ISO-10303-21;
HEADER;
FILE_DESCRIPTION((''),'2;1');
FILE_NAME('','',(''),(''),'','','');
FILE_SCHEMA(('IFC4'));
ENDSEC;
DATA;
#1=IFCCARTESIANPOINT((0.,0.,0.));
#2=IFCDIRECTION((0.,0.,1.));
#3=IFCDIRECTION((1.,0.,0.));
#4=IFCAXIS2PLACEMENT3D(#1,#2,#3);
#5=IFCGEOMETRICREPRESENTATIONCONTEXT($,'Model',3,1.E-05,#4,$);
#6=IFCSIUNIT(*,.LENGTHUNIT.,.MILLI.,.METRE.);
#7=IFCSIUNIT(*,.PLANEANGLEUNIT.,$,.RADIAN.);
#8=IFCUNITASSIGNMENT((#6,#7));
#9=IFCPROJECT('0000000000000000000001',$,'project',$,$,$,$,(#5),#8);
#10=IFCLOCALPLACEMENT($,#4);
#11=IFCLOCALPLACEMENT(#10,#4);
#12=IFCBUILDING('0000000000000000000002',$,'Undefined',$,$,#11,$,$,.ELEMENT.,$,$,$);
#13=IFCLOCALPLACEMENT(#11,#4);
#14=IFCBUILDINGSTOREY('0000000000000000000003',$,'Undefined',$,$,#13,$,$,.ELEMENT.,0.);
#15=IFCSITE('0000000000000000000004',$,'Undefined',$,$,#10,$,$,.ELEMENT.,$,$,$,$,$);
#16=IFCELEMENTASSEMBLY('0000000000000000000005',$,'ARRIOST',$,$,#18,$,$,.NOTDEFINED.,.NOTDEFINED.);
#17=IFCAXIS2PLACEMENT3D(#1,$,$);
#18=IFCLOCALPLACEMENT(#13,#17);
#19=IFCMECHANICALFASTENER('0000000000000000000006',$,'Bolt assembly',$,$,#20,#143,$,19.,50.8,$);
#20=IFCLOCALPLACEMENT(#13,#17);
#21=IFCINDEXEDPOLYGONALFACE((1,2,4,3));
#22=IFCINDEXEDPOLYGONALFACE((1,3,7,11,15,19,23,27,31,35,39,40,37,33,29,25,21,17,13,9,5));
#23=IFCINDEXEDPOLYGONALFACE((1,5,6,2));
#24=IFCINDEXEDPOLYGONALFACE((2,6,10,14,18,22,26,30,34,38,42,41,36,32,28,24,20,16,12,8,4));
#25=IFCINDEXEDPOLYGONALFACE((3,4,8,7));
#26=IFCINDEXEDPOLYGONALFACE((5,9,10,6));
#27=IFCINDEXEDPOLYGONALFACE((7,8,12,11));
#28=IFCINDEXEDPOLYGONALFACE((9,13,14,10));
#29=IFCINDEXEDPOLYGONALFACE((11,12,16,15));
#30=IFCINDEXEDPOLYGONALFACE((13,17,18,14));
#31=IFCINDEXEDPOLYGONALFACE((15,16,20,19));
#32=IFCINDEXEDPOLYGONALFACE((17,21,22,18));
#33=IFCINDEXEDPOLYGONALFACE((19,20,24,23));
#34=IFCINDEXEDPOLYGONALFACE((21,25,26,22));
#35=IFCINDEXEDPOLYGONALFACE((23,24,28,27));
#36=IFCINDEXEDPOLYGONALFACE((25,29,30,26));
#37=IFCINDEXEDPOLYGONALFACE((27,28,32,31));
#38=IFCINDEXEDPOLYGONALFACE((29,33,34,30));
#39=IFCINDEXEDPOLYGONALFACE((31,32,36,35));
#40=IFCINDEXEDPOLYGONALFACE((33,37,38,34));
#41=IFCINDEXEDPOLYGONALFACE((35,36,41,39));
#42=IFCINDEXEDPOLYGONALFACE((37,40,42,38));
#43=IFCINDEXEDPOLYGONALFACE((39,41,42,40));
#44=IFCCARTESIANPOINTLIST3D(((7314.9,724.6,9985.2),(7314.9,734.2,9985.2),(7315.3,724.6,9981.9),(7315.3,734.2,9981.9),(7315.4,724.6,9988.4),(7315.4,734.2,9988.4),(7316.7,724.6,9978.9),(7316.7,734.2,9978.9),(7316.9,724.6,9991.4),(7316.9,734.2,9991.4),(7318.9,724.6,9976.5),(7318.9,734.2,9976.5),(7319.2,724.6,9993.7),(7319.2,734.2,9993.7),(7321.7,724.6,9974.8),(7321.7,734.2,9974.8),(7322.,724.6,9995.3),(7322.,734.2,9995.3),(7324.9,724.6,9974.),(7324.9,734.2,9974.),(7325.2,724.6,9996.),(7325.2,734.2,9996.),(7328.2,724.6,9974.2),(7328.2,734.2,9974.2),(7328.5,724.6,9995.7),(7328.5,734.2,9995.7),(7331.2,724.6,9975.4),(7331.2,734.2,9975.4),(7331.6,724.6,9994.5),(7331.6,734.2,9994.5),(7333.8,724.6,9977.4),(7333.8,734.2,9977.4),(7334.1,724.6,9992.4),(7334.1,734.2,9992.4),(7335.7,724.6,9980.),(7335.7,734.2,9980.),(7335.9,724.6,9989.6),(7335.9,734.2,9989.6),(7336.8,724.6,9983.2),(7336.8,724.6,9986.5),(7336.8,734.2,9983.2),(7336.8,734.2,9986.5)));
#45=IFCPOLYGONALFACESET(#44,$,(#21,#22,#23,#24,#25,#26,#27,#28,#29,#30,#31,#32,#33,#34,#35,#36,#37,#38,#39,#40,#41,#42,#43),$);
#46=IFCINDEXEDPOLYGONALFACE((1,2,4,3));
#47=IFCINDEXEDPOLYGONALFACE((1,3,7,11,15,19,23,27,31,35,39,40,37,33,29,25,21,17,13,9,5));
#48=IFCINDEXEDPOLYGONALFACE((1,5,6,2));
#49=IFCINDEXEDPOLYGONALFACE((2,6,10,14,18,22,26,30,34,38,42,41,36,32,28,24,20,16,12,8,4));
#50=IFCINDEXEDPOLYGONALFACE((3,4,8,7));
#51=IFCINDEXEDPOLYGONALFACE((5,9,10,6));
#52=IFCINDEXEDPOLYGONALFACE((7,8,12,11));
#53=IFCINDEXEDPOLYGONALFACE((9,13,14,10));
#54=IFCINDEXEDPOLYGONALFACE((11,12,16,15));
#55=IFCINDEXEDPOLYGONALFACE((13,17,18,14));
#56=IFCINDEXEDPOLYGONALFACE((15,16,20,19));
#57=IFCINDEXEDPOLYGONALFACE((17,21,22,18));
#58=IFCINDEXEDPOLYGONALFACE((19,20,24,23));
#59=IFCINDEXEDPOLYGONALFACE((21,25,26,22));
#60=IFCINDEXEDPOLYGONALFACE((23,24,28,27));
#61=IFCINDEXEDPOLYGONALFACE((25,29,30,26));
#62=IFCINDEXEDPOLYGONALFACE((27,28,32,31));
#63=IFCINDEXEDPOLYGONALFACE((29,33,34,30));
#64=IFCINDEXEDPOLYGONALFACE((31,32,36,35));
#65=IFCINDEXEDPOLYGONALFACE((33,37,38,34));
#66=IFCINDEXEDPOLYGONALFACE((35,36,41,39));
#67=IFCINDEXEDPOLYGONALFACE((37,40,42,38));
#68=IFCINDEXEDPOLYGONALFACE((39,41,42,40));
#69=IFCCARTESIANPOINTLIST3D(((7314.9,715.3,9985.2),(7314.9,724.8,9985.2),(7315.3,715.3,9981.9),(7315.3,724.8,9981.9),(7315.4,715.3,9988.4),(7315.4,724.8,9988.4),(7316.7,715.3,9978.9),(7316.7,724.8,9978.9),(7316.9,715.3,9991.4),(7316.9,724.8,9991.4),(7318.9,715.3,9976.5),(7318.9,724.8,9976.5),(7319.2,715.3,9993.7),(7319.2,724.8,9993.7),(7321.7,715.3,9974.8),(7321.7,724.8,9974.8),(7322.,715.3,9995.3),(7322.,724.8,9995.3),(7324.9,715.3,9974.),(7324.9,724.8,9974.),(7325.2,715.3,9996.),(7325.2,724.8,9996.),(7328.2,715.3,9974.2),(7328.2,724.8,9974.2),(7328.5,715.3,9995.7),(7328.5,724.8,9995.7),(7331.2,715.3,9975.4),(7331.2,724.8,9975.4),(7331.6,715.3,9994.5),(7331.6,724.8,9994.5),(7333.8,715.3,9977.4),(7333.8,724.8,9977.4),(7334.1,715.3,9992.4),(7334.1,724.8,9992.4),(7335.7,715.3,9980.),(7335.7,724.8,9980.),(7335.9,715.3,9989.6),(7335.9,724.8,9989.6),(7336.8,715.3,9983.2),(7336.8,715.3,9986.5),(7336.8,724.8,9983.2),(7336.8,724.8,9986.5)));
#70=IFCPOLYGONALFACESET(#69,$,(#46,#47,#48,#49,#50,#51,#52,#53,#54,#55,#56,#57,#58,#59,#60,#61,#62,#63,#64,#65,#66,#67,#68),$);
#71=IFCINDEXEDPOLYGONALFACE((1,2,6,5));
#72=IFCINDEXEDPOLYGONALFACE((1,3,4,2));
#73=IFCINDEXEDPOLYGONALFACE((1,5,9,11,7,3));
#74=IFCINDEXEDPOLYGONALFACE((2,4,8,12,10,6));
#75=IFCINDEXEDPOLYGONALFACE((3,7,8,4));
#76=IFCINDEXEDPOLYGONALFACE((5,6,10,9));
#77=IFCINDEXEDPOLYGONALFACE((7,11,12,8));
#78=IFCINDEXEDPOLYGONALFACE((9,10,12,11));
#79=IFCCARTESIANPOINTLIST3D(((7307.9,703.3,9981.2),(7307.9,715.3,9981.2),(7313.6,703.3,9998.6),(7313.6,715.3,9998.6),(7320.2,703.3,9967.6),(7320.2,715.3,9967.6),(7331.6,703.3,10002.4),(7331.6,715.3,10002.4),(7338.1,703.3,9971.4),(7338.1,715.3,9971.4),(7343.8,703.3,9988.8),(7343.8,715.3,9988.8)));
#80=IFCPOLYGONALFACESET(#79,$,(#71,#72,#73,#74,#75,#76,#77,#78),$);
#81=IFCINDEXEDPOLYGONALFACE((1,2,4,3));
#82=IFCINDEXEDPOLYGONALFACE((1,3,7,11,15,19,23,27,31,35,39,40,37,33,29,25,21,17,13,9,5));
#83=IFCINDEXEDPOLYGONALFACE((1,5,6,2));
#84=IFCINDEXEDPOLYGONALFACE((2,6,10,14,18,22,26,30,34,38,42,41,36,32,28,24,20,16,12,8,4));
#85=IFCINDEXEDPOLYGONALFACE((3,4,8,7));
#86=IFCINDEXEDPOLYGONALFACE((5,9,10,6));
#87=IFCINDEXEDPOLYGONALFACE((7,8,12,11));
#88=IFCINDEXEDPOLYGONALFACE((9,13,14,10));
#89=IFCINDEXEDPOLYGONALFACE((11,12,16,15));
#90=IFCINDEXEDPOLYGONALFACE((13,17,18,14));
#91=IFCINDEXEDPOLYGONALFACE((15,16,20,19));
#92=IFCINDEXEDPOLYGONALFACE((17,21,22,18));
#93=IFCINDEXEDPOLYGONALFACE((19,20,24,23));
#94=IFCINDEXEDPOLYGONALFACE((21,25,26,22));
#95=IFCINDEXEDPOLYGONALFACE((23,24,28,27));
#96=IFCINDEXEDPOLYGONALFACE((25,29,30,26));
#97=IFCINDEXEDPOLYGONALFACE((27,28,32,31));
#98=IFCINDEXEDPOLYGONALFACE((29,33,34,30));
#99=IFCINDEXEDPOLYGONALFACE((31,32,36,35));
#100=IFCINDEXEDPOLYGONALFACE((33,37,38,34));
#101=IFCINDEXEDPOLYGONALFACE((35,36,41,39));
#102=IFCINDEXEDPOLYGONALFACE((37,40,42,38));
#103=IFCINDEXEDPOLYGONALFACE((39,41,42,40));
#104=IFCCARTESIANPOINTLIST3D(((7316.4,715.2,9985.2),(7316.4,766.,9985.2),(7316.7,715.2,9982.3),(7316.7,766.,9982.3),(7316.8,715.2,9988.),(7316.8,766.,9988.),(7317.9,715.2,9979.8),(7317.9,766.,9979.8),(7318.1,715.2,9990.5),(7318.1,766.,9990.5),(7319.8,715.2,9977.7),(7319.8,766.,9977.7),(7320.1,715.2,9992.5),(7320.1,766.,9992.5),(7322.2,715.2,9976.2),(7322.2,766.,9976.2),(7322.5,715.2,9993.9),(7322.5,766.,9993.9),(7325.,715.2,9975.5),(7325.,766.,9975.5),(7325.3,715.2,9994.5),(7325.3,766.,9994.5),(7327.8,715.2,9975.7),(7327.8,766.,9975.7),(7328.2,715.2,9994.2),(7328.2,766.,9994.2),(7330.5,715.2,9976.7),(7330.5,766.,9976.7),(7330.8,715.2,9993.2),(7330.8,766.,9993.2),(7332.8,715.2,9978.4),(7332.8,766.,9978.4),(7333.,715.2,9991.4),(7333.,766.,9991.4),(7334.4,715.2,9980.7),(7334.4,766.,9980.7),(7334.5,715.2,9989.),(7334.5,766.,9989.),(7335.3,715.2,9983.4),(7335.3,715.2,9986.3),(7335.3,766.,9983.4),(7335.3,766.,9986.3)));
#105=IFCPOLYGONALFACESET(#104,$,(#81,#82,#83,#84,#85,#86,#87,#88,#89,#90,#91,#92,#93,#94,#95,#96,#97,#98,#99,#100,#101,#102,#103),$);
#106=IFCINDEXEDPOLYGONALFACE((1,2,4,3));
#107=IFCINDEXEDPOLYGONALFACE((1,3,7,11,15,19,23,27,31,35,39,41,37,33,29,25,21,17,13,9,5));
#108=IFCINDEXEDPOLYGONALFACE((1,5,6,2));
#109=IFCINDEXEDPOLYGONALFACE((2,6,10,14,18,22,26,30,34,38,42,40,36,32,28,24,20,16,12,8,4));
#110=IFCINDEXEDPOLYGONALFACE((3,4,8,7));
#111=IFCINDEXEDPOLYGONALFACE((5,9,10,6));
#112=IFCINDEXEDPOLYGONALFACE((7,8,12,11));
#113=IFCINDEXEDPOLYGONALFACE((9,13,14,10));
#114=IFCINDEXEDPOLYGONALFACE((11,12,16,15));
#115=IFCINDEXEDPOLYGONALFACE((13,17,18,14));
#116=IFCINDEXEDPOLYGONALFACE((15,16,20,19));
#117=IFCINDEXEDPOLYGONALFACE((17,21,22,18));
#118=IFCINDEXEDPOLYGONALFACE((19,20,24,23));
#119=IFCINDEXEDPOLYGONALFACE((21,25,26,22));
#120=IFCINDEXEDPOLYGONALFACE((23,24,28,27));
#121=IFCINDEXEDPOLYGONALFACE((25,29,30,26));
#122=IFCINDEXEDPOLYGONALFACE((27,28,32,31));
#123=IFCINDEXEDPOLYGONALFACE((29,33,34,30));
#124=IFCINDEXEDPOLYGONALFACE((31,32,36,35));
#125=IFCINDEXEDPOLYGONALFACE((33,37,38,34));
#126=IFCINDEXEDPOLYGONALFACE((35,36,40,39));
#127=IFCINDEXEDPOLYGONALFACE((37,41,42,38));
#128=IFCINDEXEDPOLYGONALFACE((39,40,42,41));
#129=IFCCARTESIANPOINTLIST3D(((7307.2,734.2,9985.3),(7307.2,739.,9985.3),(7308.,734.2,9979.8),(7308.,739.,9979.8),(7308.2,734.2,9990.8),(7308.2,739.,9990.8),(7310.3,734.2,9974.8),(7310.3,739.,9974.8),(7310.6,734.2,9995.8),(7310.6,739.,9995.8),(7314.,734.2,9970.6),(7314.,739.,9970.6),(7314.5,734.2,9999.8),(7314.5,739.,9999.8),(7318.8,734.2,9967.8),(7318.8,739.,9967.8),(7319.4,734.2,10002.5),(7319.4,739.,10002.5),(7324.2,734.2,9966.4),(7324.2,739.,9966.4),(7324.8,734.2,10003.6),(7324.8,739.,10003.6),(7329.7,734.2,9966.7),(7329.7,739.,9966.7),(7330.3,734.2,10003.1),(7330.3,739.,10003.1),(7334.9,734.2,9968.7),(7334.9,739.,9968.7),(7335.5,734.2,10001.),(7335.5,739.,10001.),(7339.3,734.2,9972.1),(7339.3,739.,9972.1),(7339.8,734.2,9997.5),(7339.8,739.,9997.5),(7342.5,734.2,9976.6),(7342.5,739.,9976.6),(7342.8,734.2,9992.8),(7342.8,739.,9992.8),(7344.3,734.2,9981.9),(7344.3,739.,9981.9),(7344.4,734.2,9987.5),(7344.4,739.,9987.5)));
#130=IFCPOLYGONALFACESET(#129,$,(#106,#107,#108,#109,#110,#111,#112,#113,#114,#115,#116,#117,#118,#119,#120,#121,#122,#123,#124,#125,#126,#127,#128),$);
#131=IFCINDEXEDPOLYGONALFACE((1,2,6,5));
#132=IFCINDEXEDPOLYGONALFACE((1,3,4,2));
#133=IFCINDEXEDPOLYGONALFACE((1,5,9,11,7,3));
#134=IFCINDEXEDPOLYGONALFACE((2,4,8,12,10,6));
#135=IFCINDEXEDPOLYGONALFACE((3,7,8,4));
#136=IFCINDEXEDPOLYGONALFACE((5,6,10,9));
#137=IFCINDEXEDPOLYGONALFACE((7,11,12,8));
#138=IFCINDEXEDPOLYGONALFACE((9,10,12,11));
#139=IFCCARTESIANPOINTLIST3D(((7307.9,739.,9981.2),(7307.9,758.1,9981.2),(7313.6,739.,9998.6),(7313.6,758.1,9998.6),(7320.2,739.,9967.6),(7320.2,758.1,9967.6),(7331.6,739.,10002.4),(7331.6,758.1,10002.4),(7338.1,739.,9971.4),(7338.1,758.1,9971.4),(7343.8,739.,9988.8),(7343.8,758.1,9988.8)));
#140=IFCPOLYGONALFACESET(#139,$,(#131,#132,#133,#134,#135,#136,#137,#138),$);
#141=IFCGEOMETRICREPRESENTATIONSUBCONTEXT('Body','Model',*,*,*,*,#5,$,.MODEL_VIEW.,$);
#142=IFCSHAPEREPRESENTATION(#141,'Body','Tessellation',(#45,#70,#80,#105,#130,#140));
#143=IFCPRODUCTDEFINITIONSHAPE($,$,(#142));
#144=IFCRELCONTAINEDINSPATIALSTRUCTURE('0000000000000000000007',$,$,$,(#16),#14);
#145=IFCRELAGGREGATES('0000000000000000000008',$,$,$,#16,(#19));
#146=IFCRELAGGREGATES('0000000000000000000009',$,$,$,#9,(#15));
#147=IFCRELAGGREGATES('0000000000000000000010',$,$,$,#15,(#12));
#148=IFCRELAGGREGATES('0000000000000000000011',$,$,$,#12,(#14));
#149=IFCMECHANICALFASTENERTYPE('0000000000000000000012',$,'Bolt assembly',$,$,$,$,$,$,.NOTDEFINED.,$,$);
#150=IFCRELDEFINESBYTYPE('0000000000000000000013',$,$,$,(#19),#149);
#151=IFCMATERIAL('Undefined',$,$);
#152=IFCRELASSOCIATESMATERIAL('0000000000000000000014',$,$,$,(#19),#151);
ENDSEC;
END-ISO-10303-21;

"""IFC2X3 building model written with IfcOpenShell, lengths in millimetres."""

from ifc_helpers import new_model, si_unit, frame, origin_with_axes, origin_2d_with_axis, place, context, subcontext, project, spatial, polyline, circle, outline, extrude, source, transform, mapped, material, type_object, element, aggregate, save


model = new_model("IFC2X3")

# Units and contexts
model_context = context("Model", 3, precision=1e-05, world=origin_with_axes())
body_context = subcontext(model_context, "Body", "Model", "MODEL_VIEW")
ifc_project = project(units=[si_unit("LENGTHUNIT", "METRE", prefix="MILLI"), si_unit("PLANEANGLEUNIT", "RADIAN")], contexts=[model_context])

# Site, building, storey
site_placement = place(None, origin_with_axes())
site = spatial("IfcSite", under=ifc_project, at=site_placement, Name="Undefined", CompositionType="ELEMENT")
building_placement = place(site_placement, origin_with_axes())
building = spatial("IfcBuilding", under=site, at=building_placement, Name="Undefined", CompositionType="ELEMENT")
storey_placement = place(building_placement, origin_with_axes())
storey = spatial("IfcBuildingStorey", under=building, at=storey_placement, Name="Undefined", CompositionType="ELEMENT", Elevation=0.0)

# Element assembly
assembly_1_placement = place(storey_placement, origin_with_axes())
assembly_1 = element("IfcElementAssembly", 1, at=assembly_1_placement, inside=storey, Name="ARRIOST", AssemblyPlace="NOTDEFINED", PredefinedType="NOTDEFINED")

# Shared definitions
ifc_material_1 = material(Name="Undefined")
mechanical_fastener_type = type_object("IfcMechanicalFastenerType", Name="Bolt assembly")

# Mechanical fastener
shared_shape_1 = source(origin_with_axes(), body_context, "Body", "SweptSolid", [
    extrude(circle(Radius=11.0, at=origin_2d_with_axis()), frame((0.0, 4.6, 0.0), z_axis=(0.0, 1.0, 0.0), x_axis=(1.0, 0.0, 0.0)), (0.0, 0.0, 1.0), 9.6),
    extrude(circle(Radius=11.0, at=origin_2d_with_axis()), frame((0.0, -4.6, 0.0), z_axis=(0.0, 1.0, 0.0), x_axis=(1.0, 0.0, 0.0)), (0.0, 0.0, 1.0), 9.5),
    extrude(outline(polyline([(15.9, -9.2), (15.9, 9.2), (0.0, 18.3), (-15.9, 9.2), (-15.9, -9.2), (0.0, -18.3), (15.9, -9.2)])), frame((0.0, -16.7, 0.0), z_axis=(0.0, 1.0, 0.0), x_axis=(1.0, 0.0, 0.0)), (0.0, 0.0, 1.0), 11.9),
    extrude(circle(Radius=9.5, at=origin_2d_with_axis()), frame((0.0, -4.7, 0.0), z_axis=(0.0, 1.0, 0.0), x_axis=(1.0, 0.0, 0.0)), (0.0, 0.0, 1.0), 50.8),
    extrude(circle(Radius=18.7, at=origin_2d_with_axis()), frame((0.0, 14.2, 0.0), z_axis=(0.0, 1.0, 0.0), x_axis=(1.0, 0.0, 0.0)), (0.0, 0.0, 1.0), 4.8),
    extrude(outline(polyline([(15.9, -9.2), (15.9, 9.2), (0.0, 18.3), (-15.9, 9.2), (-15.9, -9.2), (0.0, -18.3), (15.9, -9.2)])), frame((0.0, 19.0, 0.0), z_axis=(0.0, 1.0, 0.0), x_axis=(1.0, 0.0, 0.0)), (0.0, 0.0, 1.0), 19.1),
])
mechanical_fastener_1_placement = place(assembly_1_placement, frame((7325.9, 720.0, 9985.0), z_axis=(-0.310857, 0.0, -0.950457), x_axis=(-0.950457, 0.0, 0.310857)))
mechanical_fastener_1 = element("IfcMechanicalFastener", 2, at=mechanical_fastener_1_placement, type_object=mechanical_fastener_type, material=ifc_material_1, Name="Bolt assembly", NominalDiameter=19.0, NominalLength=50.8, context=body_context, shape_type="MappedRepresentation", body=[
    mapped(shared_shape_1, transform((0.0, 0.0, 0.0))),
])
aggregate(assembly_1, [mechanical_fastener_1])

save(model, "model.ifc")
